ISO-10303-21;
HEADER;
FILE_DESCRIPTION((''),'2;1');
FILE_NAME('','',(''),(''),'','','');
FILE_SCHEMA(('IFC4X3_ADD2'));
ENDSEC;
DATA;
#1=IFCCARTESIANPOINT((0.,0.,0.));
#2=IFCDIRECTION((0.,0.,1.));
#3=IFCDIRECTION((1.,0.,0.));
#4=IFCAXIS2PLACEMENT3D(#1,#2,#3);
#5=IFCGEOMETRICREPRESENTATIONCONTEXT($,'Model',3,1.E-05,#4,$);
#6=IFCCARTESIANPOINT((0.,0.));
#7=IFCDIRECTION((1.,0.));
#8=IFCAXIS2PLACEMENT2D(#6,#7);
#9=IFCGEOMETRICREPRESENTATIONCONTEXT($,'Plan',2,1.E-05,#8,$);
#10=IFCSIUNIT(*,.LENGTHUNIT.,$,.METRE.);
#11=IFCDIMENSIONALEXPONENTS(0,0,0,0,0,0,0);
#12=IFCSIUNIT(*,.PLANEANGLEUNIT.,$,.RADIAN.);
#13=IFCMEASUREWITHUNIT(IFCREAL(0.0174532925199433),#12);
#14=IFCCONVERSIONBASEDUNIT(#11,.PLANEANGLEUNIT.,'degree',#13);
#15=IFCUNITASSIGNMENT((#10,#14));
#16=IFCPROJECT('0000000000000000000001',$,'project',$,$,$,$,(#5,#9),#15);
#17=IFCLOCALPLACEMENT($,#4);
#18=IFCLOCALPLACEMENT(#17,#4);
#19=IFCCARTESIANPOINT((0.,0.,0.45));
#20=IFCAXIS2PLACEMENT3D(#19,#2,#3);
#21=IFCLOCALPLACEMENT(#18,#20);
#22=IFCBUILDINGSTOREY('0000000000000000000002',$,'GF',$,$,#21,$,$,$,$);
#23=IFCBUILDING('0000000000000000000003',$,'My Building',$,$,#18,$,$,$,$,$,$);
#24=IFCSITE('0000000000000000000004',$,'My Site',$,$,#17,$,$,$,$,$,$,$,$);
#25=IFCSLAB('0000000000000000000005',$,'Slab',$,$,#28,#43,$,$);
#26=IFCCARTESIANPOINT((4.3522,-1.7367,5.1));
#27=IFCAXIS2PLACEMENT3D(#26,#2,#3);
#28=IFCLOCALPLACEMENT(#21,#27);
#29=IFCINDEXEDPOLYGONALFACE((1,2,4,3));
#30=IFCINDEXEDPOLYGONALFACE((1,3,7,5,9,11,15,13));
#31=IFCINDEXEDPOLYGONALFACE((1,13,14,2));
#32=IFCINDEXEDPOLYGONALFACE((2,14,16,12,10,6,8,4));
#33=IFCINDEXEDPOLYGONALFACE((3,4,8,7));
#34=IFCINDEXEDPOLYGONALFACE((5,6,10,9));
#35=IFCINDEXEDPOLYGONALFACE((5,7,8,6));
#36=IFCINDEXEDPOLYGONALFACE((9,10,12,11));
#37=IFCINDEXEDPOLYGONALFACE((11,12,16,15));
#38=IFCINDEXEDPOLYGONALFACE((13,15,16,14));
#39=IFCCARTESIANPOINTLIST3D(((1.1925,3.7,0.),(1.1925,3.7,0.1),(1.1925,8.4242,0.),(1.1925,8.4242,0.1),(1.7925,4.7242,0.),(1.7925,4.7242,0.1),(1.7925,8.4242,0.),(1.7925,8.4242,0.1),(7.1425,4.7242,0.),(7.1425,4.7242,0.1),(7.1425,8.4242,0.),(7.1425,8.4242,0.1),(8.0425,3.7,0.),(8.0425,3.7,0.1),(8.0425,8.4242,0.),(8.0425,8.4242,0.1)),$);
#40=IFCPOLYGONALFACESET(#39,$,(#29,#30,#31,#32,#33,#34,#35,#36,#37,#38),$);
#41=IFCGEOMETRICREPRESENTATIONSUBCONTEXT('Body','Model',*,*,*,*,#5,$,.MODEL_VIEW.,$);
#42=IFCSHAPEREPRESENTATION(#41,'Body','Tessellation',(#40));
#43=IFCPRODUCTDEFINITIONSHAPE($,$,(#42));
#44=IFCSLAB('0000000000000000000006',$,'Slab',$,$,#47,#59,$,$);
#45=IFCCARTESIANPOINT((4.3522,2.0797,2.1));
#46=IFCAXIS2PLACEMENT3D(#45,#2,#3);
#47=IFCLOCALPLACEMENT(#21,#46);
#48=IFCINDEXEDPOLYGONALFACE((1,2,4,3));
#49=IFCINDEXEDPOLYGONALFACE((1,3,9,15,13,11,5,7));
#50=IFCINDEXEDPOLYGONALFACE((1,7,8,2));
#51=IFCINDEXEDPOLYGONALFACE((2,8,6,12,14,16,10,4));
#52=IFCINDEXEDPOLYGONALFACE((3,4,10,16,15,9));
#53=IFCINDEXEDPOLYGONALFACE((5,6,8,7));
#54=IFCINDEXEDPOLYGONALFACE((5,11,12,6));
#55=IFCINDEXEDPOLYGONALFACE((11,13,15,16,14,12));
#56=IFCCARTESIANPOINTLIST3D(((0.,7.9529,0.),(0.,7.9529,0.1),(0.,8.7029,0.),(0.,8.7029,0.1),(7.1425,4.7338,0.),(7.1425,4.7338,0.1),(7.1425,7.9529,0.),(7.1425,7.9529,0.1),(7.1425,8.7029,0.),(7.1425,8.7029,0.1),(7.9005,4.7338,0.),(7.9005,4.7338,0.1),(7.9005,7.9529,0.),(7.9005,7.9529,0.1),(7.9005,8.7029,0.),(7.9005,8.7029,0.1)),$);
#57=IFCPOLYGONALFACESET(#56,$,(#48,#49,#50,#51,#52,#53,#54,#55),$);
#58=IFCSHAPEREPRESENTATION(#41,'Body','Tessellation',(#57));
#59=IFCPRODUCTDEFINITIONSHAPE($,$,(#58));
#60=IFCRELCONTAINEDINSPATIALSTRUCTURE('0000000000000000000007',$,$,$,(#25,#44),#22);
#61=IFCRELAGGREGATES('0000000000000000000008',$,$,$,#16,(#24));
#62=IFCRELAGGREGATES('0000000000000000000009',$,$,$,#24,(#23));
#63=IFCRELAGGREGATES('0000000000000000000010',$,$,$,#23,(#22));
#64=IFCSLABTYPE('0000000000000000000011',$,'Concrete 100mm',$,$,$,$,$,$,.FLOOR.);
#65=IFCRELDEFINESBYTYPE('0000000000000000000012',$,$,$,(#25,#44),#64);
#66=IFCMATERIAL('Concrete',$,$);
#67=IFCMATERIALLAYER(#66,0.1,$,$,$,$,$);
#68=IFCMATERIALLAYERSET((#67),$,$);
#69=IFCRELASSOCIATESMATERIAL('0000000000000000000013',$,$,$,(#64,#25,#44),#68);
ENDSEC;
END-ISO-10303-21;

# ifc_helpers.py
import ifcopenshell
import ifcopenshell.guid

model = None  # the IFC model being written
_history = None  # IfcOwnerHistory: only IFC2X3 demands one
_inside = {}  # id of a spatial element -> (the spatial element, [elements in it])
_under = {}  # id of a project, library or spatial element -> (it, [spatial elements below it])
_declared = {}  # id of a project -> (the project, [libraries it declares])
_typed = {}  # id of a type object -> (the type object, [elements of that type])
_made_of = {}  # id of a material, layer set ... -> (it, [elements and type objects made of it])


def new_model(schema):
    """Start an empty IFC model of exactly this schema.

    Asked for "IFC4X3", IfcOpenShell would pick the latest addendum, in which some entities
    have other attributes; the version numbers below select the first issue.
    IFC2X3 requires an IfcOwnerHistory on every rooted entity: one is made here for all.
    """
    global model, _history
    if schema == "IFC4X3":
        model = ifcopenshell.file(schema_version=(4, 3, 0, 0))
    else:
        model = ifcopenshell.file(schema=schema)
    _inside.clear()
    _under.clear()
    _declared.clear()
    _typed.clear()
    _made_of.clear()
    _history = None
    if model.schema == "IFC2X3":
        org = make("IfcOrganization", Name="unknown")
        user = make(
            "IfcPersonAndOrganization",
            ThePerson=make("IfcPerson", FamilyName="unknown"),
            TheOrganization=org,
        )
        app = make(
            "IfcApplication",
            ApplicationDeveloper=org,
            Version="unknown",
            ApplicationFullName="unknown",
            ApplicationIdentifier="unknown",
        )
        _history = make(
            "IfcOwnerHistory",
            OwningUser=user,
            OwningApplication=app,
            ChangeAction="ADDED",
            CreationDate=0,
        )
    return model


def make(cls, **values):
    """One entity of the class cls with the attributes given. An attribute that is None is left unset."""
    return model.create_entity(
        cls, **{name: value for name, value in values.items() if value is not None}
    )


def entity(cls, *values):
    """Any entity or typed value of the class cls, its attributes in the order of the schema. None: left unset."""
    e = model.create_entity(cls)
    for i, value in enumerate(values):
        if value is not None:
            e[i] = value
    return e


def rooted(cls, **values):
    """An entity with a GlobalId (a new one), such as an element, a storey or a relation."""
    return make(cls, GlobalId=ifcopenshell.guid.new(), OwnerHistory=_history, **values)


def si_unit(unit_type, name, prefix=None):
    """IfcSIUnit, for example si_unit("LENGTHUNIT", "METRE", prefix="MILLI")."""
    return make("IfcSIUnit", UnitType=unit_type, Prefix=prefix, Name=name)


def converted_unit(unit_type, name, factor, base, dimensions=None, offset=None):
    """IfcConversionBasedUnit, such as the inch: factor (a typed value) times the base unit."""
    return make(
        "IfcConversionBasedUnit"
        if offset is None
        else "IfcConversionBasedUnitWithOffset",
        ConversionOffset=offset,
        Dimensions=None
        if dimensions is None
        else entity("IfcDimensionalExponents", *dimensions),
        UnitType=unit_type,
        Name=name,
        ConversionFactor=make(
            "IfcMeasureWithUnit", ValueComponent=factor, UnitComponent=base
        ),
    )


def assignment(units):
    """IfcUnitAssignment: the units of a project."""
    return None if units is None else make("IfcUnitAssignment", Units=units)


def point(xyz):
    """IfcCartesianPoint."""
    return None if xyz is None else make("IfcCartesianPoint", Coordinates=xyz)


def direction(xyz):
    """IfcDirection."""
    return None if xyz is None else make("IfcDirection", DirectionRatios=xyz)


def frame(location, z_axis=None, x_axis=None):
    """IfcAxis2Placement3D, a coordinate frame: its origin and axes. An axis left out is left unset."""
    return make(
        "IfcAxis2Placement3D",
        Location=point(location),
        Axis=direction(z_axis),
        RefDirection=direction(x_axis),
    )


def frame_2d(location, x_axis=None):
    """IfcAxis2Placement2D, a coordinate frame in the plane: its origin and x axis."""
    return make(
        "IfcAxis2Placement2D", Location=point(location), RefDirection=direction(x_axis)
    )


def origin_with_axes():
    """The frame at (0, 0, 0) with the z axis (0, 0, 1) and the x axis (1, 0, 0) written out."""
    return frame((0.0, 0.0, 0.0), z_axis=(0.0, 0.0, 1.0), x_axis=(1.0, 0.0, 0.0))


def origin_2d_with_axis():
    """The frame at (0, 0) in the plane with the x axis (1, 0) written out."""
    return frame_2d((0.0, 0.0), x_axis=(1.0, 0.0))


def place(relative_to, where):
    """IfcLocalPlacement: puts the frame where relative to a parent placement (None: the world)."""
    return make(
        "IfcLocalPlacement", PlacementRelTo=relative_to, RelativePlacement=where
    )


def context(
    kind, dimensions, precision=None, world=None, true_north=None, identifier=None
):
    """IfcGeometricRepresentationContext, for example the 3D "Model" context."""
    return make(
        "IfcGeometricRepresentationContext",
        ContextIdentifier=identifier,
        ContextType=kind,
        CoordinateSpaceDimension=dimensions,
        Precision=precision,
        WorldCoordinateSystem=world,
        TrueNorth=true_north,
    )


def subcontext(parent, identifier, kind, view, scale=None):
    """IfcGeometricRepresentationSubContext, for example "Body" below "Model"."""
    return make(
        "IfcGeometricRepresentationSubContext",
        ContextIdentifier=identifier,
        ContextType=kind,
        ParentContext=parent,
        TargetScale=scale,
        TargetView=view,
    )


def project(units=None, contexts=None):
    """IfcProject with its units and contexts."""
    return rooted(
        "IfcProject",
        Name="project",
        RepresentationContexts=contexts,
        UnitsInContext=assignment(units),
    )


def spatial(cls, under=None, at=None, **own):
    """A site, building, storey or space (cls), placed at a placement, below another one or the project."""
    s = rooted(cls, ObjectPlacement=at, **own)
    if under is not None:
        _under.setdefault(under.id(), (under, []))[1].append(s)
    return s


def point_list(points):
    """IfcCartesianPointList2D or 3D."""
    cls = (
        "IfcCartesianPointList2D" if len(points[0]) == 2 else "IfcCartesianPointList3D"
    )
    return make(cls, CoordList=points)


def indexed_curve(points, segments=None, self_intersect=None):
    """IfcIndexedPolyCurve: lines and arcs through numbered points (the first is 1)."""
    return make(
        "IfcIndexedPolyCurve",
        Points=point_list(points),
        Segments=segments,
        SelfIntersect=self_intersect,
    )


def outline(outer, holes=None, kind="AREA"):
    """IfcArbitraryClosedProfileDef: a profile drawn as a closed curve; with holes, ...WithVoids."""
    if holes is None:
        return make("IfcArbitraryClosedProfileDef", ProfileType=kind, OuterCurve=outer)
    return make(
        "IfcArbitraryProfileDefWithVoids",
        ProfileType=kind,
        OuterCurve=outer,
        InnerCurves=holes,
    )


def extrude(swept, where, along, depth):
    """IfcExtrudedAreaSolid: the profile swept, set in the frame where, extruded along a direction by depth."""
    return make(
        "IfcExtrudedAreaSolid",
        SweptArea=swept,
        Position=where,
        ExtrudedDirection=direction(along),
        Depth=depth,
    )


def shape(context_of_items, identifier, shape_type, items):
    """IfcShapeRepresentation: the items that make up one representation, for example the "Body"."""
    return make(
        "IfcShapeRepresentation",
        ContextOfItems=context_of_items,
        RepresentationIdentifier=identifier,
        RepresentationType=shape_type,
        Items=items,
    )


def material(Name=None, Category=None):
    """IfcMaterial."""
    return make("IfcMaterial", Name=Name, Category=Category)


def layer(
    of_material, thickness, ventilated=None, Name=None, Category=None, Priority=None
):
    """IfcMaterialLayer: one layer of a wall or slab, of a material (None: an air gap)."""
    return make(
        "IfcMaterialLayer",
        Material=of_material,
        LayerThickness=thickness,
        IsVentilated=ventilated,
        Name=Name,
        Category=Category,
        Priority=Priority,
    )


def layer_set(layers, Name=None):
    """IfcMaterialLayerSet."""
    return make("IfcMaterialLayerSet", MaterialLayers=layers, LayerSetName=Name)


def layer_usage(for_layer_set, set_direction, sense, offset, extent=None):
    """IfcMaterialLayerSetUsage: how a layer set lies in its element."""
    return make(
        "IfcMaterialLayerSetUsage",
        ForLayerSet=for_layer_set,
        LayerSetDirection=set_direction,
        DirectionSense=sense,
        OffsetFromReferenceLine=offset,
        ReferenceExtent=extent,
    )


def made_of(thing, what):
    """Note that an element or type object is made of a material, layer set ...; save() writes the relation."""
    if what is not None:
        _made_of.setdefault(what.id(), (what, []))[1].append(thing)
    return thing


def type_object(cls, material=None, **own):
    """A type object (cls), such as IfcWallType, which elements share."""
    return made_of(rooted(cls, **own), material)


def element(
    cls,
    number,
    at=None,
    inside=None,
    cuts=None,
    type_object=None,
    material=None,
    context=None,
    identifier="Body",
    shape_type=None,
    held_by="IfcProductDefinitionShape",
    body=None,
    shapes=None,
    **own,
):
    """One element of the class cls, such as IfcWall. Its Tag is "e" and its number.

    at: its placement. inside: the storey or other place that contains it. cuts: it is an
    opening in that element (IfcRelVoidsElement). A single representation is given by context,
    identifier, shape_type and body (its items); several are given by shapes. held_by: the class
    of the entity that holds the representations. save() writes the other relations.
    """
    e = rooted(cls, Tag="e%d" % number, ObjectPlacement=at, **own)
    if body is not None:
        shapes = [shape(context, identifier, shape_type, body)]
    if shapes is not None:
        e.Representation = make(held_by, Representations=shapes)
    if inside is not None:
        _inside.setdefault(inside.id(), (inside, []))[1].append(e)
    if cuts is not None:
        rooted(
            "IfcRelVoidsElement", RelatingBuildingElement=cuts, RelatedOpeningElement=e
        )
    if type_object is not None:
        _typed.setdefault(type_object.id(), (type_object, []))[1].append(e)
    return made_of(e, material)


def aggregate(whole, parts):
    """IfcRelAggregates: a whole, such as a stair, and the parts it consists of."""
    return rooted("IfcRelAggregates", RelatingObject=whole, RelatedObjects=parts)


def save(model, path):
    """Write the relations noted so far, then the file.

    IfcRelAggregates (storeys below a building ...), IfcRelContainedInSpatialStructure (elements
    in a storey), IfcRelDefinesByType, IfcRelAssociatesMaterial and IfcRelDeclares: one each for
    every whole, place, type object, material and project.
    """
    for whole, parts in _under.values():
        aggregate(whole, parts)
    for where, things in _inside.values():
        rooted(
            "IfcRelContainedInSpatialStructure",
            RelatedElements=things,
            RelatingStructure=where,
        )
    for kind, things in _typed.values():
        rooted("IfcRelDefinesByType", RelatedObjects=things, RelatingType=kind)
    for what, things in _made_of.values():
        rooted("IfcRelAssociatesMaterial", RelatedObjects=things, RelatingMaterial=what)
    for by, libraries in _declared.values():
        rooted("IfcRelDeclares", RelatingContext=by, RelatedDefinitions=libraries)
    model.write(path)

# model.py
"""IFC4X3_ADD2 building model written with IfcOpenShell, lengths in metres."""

from ifc_helpers import new_model, entity, si_unit, converted_unit, frame, origin_with_axes, origin_2d_with_axis, place, context, subcontext, project, spatial, indexed_curve, outline, extrude, material, layer, layer_set, layer_usage, type_object, element, save


model = new_model("IFC4X3_ADD2")

# Units and contexts
model_context = context("Model", 3, precision=1e-05, world=origin_with_axes())
plan_context = context("Plan", 2, precision=1e-05, world=origin_2d_with_axis())
body_context = subcontext(model_context, "Body", "Model", "MODEL_VIEW")
ifc_project = project(units=[si_unit("LENGTHUNIT", "METRE"), converted_unit("PLANEANGLEUNIT", "degree", entity("IfcReal", 0.0174532925199433), si_unit("PLANEANGLEUNIT", "RADIAN"), dimensions=[0, 0, 0, 0, 0, 0, 0])], contexts=[model_context, plan_context])

# Site, building, storey
site_placement = place(None, origin_with_axes())
site = spatial("IfcSite", under=ifc_project, at=site_placement, Name="My Site")
building_placement = place(site_placement, origin_with_axes())
building = spatial("IfcBuilding", under=site, at=building_placement, Name="My Building")
storey_placement = place(building_placement, frame((0.0, 0.0, 0.45), z_axis=(0.0, 0.0, 1.0), x_axis=(1.0, 0.0, 0.0)))
storey = spatial("IfcBuildingStorey", under=building, at=storey_placement, Name="GF")

# Slabs
ifc_material_1 = material(Name="Concrete")
ifc_layer = layer(ifc_material_1, 0.1)
ifc_layer_set = layer_set([ifc_layer])
ifc_layer_usage_1 = layer_usage(ifc_layer_set, "AXIS3", "POSITIVE", 0.0)
slab_type = type_object("IfcSlabType", Name="Concrete 100mm", PredefinedType="FLOOR", material=ifc_layer_set)
slab_1_placement = place(storey_placement, frame((4.3522, -1.7367, 5.1), z_axis=(0.0, 0.0, 1.0), x_axis=(1.0, 0.0, 0.0)))
element("IfcSlab", 1, at=slab_1_placement, inside=storey, type_object=slab_type, material=ifc_layer_usage_1, Name="Slab", context=body_context, shape_type="SweptSolid", body=[
    extrude(outline(indexed_curve([(8.0425, 3.7), (8.0425, 8.4242), (7.1425, 8.4242), (7.1425, 4.7242), (1.7925, 4.7242), (1.7925, 8.4242), (1.1925, 8.4242), (1.1925, 3.7), (8.0425, 3.7)])), origin_with_axes(), (0.0, 0.0, 1.0), 0.1),
])
ifc_layer_usage_2 = layer_usage(ifc_layer_set, "AXIS3", "POSITIVE", 0.0)
slab_2_placement = place(storey_placement, frame((4.3522, 2.0797, 2.1), z_axis=(0.0, 0.0, 1.0), x_axis=(1.0, 0.0, 0.0)))
element("IfcSlab", 2, at=slab_2_placement, inside=storey, type_object=slab_type, material=ifc_layer_usage_2, Name="Slab", context=body_context, shape_type="SweptSolid", body=[
    extrude(outline(indexed_curve([(0.0, 8.7029), (7.1425, 8.7029), (7.9005, 8.7029), (7.9005, 7.9529), (7.9005, 4.7338), (7.1425, 4.7338), (7.1425, 7.9529), (0.0, 7.9529), (0.0, 8.7029)])), origin_with_axes(), (0.0, 0.0, 1.0), 0.1),
])

save(model, "model.ifc")
